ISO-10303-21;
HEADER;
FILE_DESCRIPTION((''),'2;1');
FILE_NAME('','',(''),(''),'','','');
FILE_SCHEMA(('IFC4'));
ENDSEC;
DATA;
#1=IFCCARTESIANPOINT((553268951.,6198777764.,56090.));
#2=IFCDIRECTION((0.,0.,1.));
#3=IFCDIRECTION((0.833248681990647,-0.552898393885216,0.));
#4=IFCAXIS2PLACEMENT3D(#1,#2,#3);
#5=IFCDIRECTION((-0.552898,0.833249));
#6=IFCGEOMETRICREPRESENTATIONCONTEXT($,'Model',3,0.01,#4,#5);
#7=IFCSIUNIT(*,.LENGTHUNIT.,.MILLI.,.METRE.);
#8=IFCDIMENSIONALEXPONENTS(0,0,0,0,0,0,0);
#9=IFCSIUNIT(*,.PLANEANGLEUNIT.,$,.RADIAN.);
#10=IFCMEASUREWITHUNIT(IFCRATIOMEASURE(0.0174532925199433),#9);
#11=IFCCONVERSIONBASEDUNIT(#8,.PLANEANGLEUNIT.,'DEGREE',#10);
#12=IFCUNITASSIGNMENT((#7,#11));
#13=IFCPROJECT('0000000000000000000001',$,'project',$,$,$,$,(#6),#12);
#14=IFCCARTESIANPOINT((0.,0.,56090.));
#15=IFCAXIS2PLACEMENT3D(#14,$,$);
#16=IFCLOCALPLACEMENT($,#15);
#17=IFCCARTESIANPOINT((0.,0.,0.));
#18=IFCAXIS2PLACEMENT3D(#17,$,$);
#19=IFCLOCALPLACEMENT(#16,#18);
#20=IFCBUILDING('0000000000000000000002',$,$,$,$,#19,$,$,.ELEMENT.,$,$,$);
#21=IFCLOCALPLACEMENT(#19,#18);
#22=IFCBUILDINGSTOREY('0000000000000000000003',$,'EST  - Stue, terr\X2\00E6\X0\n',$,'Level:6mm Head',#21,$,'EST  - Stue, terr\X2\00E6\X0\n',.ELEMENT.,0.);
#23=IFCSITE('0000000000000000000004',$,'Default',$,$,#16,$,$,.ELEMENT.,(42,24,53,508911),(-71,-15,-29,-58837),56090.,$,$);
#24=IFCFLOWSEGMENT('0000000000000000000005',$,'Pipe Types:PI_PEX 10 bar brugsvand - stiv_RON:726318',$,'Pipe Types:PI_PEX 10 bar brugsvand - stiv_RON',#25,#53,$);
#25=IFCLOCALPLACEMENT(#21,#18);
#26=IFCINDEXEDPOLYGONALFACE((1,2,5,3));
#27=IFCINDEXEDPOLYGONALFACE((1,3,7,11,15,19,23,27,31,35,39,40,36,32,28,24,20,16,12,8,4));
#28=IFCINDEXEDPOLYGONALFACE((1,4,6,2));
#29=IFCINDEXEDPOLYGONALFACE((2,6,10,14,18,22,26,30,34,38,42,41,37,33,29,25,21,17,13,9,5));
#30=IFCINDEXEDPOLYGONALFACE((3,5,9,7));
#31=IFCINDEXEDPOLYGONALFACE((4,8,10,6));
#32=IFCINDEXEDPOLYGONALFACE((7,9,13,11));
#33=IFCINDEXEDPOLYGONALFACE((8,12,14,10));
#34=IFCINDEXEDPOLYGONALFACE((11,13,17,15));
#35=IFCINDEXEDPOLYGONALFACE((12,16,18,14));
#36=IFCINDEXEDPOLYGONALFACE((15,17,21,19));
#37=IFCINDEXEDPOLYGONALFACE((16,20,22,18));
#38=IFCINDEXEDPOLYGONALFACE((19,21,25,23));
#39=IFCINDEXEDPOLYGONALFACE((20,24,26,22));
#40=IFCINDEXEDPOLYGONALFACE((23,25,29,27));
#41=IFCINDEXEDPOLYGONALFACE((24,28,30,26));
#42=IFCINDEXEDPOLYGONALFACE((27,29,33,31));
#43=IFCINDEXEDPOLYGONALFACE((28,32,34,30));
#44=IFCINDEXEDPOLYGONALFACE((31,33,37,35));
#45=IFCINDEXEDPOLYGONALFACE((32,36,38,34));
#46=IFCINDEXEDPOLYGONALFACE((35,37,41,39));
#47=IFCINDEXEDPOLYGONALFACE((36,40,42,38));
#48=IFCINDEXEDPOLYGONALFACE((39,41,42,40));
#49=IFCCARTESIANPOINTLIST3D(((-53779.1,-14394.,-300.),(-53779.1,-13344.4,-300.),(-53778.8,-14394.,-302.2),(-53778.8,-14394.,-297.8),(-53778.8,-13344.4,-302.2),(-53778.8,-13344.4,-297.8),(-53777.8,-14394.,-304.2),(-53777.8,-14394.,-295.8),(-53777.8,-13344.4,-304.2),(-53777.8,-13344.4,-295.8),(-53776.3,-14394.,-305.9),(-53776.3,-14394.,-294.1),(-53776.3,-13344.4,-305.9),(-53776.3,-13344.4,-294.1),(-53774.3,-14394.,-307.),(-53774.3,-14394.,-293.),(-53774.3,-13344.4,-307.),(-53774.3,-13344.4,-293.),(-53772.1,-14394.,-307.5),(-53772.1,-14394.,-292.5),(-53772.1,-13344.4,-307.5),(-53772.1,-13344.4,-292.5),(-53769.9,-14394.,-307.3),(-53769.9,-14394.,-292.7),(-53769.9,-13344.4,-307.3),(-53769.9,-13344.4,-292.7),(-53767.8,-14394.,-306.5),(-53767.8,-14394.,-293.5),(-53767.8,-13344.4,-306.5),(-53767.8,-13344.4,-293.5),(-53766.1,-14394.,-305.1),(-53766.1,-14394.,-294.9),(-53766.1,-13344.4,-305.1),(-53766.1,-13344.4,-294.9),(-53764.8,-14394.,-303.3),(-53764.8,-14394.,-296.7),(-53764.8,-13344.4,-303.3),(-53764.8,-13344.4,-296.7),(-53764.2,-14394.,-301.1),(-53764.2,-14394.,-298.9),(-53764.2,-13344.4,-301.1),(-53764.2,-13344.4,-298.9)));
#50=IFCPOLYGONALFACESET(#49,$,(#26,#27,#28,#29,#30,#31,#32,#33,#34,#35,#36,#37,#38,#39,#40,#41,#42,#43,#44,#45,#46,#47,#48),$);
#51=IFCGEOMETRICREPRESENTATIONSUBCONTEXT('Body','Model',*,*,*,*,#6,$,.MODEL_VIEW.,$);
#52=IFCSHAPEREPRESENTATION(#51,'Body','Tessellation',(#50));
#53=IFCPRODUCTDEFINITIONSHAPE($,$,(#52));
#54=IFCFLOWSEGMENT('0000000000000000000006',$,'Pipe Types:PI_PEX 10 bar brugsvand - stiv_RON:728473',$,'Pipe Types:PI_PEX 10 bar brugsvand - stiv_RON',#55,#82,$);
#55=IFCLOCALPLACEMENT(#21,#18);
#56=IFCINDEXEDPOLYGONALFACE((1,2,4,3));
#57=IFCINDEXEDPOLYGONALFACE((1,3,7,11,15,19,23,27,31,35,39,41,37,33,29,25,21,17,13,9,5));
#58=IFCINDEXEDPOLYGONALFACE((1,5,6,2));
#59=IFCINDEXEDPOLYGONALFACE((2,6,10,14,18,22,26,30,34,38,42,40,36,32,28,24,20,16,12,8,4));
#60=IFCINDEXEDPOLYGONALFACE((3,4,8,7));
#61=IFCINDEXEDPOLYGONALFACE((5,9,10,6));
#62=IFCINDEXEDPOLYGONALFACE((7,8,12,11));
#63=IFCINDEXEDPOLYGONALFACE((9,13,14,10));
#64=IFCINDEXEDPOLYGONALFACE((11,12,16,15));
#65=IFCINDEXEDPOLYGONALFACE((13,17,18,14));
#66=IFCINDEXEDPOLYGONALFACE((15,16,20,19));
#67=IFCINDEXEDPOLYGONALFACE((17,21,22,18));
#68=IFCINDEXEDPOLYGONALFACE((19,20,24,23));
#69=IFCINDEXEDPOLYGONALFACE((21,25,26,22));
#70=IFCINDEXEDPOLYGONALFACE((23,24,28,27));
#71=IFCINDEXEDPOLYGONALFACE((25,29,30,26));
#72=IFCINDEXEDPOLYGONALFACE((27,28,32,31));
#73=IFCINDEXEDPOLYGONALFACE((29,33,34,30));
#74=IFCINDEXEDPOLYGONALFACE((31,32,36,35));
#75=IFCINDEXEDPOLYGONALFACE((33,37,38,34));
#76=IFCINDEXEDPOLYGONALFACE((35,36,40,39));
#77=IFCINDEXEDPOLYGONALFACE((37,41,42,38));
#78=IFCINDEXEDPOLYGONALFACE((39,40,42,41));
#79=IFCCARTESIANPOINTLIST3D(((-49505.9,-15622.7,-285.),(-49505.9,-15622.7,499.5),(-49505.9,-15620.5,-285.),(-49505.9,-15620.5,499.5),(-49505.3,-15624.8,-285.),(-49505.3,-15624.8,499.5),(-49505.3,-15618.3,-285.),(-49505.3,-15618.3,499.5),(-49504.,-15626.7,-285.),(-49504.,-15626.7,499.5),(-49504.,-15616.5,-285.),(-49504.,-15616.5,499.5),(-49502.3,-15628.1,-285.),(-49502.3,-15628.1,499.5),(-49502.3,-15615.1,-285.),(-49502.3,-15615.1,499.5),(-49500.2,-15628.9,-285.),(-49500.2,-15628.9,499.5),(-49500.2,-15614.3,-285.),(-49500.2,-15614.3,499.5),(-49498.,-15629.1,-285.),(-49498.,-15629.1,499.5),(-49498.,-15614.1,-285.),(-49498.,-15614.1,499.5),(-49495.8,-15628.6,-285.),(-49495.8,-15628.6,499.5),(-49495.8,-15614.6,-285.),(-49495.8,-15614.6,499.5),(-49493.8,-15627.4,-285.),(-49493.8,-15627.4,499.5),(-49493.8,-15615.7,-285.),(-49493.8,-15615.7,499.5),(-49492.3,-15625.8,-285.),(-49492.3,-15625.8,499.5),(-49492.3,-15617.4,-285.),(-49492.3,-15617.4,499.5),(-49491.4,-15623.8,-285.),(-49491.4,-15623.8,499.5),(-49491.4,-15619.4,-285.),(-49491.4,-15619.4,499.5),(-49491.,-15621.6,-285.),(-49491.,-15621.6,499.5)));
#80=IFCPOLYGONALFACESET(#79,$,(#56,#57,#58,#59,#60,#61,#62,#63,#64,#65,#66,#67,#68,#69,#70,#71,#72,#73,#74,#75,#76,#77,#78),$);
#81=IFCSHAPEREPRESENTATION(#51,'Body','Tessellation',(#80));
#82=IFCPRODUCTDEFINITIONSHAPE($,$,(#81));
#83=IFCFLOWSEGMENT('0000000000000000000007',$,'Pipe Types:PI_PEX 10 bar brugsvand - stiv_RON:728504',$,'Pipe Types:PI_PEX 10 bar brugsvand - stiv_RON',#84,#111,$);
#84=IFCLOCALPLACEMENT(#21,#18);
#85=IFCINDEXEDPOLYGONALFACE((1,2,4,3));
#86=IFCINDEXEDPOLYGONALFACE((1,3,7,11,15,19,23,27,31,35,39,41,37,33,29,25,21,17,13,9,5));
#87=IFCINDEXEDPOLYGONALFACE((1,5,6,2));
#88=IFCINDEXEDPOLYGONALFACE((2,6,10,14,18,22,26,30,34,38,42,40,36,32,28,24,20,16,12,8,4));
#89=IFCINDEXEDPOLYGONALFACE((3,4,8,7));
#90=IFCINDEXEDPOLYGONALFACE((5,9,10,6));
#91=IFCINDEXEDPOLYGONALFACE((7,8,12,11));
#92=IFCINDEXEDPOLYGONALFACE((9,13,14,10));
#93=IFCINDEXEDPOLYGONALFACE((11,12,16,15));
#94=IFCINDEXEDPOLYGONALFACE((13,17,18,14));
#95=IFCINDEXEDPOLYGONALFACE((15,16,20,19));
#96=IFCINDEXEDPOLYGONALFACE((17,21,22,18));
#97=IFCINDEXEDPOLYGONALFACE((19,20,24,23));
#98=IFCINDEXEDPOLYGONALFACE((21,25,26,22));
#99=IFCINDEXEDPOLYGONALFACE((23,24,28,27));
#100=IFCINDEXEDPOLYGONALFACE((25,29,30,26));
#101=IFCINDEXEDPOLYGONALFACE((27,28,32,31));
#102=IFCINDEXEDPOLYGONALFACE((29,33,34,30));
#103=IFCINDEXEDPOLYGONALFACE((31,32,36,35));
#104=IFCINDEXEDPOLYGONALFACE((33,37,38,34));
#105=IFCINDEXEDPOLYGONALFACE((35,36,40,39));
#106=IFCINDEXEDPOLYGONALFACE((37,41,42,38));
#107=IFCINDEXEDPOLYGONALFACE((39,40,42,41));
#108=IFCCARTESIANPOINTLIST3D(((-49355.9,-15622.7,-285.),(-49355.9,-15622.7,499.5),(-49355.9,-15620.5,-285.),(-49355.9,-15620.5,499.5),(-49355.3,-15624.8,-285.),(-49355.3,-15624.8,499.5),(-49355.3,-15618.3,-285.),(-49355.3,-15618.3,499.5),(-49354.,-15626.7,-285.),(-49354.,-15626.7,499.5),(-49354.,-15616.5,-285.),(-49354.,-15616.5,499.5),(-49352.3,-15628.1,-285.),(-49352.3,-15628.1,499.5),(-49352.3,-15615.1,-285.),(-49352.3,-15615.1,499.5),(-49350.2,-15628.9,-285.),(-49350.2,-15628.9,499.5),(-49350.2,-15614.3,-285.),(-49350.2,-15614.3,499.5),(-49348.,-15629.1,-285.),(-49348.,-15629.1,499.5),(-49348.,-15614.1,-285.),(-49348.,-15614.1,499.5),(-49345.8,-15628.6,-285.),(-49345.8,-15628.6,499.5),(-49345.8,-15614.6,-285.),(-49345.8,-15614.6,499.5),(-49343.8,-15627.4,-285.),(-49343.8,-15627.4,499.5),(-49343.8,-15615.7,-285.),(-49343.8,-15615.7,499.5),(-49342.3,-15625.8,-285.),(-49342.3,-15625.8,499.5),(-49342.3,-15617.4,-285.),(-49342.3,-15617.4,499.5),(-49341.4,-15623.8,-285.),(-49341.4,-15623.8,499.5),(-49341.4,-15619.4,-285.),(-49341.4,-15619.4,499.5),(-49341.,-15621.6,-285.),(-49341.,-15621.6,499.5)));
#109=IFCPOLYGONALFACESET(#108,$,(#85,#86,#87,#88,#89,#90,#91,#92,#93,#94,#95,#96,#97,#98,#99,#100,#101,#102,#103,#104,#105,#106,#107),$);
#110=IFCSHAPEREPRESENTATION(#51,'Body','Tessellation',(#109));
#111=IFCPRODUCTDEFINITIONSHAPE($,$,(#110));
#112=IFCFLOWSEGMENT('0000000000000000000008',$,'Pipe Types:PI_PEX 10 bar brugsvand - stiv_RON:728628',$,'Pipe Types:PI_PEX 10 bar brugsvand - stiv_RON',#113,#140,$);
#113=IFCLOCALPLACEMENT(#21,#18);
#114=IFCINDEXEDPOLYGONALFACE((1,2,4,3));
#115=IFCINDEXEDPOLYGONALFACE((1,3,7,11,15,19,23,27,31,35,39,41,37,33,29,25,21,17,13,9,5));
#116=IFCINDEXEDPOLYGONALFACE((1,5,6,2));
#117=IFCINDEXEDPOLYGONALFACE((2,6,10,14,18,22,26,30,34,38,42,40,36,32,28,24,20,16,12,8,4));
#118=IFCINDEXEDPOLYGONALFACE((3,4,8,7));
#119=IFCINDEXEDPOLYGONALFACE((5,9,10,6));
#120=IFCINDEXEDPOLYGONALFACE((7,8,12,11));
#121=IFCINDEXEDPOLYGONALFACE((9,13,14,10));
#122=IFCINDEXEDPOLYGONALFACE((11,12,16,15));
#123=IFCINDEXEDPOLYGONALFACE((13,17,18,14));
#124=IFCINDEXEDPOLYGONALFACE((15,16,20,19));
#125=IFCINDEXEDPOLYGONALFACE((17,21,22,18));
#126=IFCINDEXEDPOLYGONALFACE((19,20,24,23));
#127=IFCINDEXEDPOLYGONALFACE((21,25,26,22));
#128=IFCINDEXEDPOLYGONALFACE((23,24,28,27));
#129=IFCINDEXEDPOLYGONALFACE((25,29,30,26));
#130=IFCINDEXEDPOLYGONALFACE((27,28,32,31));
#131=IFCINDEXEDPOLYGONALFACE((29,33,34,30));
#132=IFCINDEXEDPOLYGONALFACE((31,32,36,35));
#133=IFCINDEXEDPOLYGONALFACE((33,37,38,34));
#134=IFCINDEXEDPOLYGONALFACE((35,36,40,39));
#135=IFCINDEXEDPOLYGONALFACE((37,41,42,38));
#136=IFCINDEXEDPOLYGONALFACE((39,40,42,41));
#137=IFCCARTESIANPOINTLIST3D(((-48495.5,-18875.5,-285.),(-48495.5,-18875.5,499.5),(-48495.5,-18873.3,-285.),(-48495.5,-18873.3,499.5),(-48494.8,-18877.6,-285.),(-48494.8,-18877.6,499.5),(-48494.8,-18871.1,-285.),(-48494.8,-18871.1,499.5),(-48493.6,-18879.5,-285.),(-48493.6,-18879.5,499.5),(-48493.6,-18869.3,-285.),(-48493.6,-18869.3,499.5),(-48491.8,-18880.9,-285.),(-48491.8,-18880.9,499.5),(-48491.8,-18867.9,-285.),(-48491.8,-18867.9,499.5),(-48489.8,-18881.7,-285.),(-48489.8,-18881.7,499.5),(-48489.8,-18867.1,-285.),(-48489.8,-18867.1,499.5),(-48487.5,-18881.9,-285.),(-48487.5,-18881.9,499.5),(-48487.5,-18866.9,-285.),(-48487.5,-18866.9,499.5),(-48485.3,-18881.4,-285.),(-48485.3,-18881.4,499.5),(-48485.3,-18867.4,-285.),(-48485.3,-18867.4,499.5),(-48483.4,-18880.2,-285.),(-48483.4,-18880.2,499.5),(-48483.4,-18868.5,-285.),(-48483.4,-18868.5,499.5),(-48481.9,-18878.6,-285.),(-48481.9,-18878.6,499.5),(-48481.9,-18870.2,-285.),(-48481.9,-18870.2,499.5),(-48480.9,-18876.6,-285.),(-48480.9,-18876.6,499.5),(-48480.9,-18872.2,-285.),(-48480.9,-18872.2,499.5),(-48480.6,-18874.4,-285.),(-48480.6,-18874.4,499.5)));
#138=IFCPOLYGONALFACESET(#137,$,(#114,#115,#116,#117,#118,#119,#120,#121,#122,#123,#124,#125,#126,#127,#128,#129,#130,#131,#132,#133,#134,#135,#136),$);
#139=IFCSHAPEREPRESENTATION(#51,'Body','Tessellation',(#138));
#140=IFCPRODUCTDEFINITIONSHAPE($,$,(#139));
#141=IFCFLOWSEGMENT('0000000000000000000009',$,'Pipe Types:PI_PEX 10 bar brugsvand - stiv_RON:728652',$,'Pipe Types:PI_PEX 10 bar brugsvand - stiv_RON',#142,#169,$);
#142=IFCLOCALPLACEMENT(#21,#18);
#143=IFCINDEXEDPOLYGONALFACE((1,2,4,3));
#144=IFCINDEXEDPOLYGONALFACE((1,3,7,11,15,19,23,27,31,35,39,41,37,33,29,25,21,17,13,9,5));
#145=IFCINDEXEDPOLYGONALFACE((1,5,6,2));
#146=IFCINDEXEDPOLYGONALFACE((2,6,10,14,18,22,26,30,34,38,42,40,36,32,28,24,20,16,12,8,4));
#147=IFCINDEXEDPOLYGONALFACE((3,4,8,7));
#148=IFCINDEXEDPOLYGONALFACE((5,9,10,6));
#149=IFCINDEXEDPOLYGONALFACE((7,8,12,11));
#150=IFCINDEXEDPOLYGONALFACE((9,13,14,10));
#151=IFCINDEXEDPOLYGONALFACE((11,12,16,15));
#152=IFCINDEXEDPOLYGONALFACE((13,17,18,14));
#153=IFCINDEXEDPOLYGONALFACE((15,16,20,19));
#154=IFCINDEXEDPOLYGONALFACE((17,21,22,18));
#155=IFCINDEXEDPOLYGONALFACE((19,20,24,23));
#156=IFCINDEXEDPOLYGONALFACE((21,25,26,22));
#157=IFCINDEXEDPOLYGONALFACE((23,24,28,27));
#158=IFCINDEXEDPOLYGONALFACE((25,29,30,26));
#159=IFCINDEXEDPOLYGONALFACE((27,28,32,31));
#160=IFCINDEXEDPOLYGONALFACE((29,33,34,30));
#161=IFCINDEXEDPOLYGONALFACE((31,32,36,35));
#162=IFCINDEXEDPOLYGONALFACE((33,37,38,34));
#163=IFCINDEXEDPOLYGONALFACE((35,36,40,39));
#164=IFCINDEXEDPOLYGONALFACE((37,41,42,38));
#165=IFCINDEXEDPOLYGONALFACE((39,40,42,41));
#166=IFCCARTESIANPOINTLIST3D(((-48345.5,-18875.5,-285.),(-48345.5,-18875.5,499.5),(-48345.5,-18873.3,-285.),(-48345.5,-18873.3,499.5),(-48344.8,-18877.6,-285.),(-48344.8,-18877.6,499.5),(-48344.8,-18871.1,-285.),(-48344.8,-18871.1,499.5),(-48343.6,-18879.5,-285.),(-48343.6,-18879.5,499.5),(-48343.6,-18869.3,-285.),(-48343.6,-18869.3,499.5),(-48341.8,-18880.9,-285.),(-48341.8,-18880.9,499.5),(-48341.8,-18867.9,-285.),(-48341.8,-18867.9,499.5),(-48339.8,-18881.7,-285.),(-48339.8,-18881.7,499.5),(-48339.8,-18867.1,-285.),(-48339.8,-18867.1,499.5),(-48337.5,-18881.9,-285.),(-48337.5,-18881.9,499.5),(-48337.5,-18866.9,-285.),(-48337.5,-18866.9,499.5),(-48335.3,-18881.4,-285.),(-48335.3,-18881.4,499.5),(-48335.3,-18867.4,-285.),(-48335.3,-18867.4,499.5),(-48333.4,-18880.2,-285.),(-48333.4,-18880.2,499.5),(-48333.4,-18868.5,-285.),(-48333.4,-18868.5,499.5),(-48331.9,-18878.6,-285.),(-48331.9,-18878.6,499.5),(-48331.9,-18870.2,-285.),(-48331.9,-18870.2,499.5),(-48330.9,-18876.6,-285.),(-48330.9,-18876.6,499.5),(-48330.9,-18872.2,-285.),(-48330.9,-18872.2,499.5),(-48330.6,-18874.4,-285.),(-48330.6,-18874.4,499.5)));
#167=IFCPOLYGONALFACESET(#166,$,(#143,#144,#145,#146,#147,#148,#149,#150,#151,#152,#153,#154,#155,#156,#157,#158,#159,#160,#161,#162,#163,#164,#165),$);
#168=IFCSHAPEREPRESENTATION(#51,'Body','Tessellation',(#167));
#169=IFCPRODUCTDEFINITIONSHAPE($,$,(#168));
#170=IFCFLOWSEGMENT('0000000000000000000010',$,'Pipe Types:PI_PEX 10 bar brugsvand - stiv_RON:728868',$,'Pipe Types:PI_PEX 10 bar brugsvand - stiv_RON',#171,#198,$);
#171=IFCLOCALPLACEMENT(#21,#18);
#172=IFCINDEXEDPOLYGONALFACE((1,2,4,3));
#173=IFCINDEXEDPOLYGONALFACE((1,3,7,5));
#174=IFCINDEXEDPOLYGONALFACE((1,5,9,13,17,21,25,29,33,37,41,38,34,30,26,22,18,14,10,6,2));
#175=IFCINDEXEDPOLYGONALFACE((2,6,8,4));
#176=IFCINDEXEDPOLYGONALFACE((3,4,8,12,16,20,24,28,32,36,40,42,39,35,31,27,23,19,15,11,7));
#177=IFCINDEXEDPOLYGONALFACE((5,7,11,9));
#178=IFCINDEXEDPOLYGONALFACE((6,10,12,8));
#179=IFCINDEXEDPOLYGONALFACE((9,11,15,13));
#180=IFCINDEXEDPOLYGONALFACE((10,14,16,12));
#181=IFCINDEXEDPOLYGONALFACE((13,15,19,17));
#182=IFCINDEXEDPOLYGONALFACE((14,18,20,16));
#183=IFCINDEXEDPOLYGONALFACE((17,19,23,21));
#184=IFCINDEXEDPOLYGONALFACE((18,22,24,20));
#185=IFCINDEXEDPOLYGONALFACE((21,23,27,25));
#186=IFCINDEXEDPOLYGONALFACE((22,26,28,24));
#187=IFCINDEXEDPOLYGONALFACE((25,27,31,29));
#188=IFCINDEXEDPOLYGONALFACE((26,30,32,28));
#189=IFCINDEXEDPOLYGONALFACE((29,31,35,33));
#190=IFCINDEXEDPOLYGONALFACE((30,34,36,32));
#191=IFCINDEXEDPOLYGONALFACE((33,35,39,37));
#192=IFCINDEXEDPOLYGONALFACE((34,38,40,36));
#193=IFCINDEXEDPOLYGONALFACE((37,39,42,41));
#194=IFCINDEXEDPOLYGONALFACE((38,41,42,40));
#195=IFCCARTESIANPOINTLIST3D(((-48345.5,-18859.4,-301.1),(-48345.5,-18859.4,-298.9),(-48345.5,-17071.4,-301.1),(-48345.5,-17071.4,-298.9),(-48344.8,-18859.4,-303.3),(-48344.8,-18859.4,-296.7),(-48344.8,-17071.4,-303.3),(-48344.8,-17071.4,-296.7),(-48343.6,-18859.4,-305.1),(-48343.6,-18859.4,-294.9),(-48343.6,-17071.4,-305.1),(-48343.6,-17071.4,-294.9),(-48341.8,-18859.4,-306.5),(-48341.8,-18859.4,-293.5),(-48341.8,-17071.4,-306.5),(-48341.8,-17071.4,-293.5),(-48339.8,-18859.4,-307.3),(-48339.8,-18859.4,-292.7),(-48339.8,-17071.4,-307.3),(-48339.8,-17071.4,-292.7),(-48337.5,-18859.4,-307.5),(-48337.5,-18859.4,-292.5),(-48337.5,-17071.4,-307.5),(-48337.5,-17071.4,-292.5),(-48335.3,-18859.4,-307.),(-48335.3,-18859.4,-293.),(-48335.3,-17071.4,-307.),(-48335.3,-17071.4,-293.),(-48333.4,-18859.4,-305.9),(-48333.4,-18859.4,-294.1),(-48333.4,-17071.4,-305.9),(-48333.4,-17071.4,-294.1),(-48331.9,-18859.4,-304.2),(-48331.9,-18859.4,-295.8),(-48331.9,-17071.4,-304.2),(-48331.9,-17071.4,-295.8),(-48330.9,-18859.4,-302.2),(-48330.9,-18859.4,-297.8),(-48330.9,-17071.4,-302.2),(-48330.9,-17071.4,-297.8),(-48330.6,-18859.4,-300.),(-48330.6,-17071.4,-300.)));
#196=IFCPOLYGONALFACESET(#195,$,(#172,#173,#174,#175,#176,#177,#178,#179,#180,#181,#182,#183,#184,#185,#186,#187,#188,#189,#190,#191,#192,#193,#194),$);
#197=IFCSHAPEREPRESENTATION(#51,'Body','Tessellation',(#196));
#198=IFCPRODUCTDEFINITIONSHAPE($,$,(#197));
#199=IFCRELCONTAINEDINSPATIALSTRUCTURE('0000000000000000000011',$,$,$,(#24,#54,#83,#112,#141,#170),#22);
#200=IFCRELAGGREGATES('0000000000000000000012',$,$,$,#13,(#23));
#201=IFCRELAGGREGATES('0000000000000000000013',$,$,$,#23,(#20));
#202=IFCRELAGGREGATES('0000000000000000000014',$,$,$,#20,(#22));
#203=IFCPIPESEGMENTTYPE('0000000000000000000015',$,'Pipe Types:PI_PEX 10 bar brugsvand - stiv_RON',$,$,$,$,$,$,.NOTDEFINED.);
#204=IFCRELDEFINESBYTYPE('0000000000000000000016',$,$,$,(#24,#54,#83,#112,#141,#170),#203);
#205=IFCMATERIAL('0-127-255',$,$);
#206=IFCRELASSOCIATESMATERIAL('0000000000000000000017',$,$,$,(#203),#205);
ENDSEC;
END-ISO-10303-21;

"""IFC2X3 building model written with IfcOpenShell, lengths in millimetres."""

from ifc_helpers import new_model, entity, si_unit, converted_unit, direction, frame, frame_2d, origin, origin_2d_with_axis, place, context, subcontext, project, spatial, circle, extrude, material, type_object, element, save


model = new_model("IFC2X3")

# Units and contexts
model_context = context("Model", 3, precision=0.01, world=frame((553268951.0, 6198777764.0, 56090.0), z_axis=(0.0, 0.0, 1.0), x_axis=(0.833248681990647, -0.552898393885216, 0.0)), true_north=direction((-0.552898, 0.833249)))
body_context = subcontext(model_context, "Body", "Model", "MODEL_VIEW")
ifc_project = project(units=[si_unit("LENGTHUNIT", "METRE", prefix="MILLI"), converted_unit("PLANEANGLEUNIT", "DEGREE", entity("IfcRatioMeasure", 0.0174532925199433), si_unit("PLANEANGLEUNIT", "RADIAN"), dimensions=[0, 0, 0, 0, 0, 0, 0])], contexts=[model_context])

# Site, building, storey
site_placement = place(None, frame((0.0, 0.0, 56090.0)))
site = spatial("IfcSite", under=ifc_project, at=site_placement, Name="Default", CompositionType="ELEMENT", RefLatitude=(42, 24, 53, 508911), RefLongitude=(-71, -15, -29, -58837), RefElevation=56090.0)
building_placement = place(site_placement, origin())
building = spatial("IfcBuilding", under=site, at=building_placement, CompositionType="ELEMENT")
storey_placement = place(building_placement, frame((0.0, 0.0, 0.0)))
storey = spatial("IfcBuildingStorey", under=building, at=storey_placement, Name="EST  - Stue, terræn", ObjectType="Level:6mm Head", LongName="EST  - Stue, terræn", CompositionType="ELEMENT", Elevation=0.0)

# Flow segments
ifc_material_1 = material(Name="0-127-255")
pipe_segment_type_1 = type_object("IfcPipeSegmentType", Name="Pipe Types:PI_PEX 10 bar brugsvand - stiv_RON", PredefinedType="NOTDEFINED", material=ifc_material_1)
flow_segment_1_placement = place(storey_placement, origin())
element("IfcFlowSegment", 1, at=flow_segment_1_placement, inside=storey, type_object=pipe_segment_type_1, Name="Pipe Types:PI_PEX 10 bar brugsvand - stiv_RON:726318", ObjectType="Pipe Types:PI_PEX 10 bar brugsvand - stiv_RON", context=body_context, shape_type="SweptSolid", body=[
    extrude(circle(Radius=7.5, at=frame_2d((0.0, 0.0), x_axis=(1.0, 0.0))), frame((-53771.6, -14394.0, -300.0), z_axis=(0.0, 1.0, 0.0), x_axis=(-1.0, 0.0, 0.0)), (0.0, 0.0, 1.0), 1049.6),
])
flow_segment_2_placement = place(storey_placement, origin())
element("IfcFlowSegment", 2, at=flow_segment_2_placement, inside=storey, type_object=pipe_segment_type_1, Name="Pipe Types:PI_PEX 10 bar brugsvand - stiv_RON:728473", ObjectType="Pipe Types:PI_PEX 10 bar brugsvand - stiv_RON", context=body_context, shape_type="SweptSolid", body=[
    extrude(circle(Radius=7.5, at=frame_2d((0.0, 0.0), x_axis=(1.0, 0.0))), frame((-49498.5, -15621.6, -285.0)), (0.0, 0.0, 1.0), 784.5),
])
flow_segment_3_placement = place(storey_placement, origin())
element("IfcFlowSegment", 3, at=flow_segment_3_placement, inside=storey, type_object=pipe_segment_type_1, Name="Pipe Types:PI_PEX 10 bar brugsvand - stiv_RON:728504", ObjectType="Pipe Types:PI_PEX 10 bar brugsvand - stiv_RON", context=body_context, shape_type="SweptSolid", body=[
    extrude(circle(Radius=7.5, at=origin_2d_with_axis()), frame((-49348.5, -15621.6, -285.0)), (0.0, 0.0, 1.0), 784.5),
])
flow_segment_4_placement = place(storey_placement, origin())
element("IfcFlowSegment", 4, at=flow_segment_4_placement, inside=storey, type_object=pipe_segment_type_1, Name="Pipe Types:PI_PEX 10 bar brugsvand - stiv_RON:728628", ObjectType="Pipe Types:PI_PEX 10 bar brugsvand - stiv_RON", context=body_context, shape_type="SweptSolid", body=[
    extrude(circle(Radius=7.5, at=origin_2d_with_axis()), frame((-48488.1, -18874.4, -285.0)), (0.0, 0.0, 1.0), 784.5),
])
flow_segment_5_placement = place(storey_placement, origin())
element("IfcFlowSegment", 5, at=flow_segment_5_placement, inside=storey, type_object=pipe_segment_type_1, Name="Pipe Types:PI_PEX 10 bar brugsvand - stiv_RON:728652", ObjectType="Pipe Types:PI_PEX 10 bar brugsvand - stiv_RON", context=body_context, shape_type="SweptSolid", body=[
    extrude(circle(Radius=7.5, at=origin_2d_with_axis()), frame((-48338.1, -18874.4, -285.0)), (0.0, 0.0, 1.0), 784.5),
])
flow_segment_6_placement = place(storey_placement, origin())
element("IfcFlowSegment", 6, at=flow_segment_6_placement, inside=storey, type_object=pipe_segment_type_1, Name="Pipe Types:PI_PEX 10 bar brugsvand - stiv_RON:728868", ObjectType="Pipe Types:PI_PEX 10 bar brugsvand - stiv_RON", context=body_context, shape_type="SweptSolid", body=[
    extrude(circle(Radius=7.5, at=origin_2d_with_axis()), frame((-48338.1, -18859.4, -300.0), z_axis=(0.0, 1.0, 0.0), x_axis=(1.0, 0.0, 0.0)), (0.0, 0.0, 1.0), 1788.0),
])

save(model, "model.ifc")
